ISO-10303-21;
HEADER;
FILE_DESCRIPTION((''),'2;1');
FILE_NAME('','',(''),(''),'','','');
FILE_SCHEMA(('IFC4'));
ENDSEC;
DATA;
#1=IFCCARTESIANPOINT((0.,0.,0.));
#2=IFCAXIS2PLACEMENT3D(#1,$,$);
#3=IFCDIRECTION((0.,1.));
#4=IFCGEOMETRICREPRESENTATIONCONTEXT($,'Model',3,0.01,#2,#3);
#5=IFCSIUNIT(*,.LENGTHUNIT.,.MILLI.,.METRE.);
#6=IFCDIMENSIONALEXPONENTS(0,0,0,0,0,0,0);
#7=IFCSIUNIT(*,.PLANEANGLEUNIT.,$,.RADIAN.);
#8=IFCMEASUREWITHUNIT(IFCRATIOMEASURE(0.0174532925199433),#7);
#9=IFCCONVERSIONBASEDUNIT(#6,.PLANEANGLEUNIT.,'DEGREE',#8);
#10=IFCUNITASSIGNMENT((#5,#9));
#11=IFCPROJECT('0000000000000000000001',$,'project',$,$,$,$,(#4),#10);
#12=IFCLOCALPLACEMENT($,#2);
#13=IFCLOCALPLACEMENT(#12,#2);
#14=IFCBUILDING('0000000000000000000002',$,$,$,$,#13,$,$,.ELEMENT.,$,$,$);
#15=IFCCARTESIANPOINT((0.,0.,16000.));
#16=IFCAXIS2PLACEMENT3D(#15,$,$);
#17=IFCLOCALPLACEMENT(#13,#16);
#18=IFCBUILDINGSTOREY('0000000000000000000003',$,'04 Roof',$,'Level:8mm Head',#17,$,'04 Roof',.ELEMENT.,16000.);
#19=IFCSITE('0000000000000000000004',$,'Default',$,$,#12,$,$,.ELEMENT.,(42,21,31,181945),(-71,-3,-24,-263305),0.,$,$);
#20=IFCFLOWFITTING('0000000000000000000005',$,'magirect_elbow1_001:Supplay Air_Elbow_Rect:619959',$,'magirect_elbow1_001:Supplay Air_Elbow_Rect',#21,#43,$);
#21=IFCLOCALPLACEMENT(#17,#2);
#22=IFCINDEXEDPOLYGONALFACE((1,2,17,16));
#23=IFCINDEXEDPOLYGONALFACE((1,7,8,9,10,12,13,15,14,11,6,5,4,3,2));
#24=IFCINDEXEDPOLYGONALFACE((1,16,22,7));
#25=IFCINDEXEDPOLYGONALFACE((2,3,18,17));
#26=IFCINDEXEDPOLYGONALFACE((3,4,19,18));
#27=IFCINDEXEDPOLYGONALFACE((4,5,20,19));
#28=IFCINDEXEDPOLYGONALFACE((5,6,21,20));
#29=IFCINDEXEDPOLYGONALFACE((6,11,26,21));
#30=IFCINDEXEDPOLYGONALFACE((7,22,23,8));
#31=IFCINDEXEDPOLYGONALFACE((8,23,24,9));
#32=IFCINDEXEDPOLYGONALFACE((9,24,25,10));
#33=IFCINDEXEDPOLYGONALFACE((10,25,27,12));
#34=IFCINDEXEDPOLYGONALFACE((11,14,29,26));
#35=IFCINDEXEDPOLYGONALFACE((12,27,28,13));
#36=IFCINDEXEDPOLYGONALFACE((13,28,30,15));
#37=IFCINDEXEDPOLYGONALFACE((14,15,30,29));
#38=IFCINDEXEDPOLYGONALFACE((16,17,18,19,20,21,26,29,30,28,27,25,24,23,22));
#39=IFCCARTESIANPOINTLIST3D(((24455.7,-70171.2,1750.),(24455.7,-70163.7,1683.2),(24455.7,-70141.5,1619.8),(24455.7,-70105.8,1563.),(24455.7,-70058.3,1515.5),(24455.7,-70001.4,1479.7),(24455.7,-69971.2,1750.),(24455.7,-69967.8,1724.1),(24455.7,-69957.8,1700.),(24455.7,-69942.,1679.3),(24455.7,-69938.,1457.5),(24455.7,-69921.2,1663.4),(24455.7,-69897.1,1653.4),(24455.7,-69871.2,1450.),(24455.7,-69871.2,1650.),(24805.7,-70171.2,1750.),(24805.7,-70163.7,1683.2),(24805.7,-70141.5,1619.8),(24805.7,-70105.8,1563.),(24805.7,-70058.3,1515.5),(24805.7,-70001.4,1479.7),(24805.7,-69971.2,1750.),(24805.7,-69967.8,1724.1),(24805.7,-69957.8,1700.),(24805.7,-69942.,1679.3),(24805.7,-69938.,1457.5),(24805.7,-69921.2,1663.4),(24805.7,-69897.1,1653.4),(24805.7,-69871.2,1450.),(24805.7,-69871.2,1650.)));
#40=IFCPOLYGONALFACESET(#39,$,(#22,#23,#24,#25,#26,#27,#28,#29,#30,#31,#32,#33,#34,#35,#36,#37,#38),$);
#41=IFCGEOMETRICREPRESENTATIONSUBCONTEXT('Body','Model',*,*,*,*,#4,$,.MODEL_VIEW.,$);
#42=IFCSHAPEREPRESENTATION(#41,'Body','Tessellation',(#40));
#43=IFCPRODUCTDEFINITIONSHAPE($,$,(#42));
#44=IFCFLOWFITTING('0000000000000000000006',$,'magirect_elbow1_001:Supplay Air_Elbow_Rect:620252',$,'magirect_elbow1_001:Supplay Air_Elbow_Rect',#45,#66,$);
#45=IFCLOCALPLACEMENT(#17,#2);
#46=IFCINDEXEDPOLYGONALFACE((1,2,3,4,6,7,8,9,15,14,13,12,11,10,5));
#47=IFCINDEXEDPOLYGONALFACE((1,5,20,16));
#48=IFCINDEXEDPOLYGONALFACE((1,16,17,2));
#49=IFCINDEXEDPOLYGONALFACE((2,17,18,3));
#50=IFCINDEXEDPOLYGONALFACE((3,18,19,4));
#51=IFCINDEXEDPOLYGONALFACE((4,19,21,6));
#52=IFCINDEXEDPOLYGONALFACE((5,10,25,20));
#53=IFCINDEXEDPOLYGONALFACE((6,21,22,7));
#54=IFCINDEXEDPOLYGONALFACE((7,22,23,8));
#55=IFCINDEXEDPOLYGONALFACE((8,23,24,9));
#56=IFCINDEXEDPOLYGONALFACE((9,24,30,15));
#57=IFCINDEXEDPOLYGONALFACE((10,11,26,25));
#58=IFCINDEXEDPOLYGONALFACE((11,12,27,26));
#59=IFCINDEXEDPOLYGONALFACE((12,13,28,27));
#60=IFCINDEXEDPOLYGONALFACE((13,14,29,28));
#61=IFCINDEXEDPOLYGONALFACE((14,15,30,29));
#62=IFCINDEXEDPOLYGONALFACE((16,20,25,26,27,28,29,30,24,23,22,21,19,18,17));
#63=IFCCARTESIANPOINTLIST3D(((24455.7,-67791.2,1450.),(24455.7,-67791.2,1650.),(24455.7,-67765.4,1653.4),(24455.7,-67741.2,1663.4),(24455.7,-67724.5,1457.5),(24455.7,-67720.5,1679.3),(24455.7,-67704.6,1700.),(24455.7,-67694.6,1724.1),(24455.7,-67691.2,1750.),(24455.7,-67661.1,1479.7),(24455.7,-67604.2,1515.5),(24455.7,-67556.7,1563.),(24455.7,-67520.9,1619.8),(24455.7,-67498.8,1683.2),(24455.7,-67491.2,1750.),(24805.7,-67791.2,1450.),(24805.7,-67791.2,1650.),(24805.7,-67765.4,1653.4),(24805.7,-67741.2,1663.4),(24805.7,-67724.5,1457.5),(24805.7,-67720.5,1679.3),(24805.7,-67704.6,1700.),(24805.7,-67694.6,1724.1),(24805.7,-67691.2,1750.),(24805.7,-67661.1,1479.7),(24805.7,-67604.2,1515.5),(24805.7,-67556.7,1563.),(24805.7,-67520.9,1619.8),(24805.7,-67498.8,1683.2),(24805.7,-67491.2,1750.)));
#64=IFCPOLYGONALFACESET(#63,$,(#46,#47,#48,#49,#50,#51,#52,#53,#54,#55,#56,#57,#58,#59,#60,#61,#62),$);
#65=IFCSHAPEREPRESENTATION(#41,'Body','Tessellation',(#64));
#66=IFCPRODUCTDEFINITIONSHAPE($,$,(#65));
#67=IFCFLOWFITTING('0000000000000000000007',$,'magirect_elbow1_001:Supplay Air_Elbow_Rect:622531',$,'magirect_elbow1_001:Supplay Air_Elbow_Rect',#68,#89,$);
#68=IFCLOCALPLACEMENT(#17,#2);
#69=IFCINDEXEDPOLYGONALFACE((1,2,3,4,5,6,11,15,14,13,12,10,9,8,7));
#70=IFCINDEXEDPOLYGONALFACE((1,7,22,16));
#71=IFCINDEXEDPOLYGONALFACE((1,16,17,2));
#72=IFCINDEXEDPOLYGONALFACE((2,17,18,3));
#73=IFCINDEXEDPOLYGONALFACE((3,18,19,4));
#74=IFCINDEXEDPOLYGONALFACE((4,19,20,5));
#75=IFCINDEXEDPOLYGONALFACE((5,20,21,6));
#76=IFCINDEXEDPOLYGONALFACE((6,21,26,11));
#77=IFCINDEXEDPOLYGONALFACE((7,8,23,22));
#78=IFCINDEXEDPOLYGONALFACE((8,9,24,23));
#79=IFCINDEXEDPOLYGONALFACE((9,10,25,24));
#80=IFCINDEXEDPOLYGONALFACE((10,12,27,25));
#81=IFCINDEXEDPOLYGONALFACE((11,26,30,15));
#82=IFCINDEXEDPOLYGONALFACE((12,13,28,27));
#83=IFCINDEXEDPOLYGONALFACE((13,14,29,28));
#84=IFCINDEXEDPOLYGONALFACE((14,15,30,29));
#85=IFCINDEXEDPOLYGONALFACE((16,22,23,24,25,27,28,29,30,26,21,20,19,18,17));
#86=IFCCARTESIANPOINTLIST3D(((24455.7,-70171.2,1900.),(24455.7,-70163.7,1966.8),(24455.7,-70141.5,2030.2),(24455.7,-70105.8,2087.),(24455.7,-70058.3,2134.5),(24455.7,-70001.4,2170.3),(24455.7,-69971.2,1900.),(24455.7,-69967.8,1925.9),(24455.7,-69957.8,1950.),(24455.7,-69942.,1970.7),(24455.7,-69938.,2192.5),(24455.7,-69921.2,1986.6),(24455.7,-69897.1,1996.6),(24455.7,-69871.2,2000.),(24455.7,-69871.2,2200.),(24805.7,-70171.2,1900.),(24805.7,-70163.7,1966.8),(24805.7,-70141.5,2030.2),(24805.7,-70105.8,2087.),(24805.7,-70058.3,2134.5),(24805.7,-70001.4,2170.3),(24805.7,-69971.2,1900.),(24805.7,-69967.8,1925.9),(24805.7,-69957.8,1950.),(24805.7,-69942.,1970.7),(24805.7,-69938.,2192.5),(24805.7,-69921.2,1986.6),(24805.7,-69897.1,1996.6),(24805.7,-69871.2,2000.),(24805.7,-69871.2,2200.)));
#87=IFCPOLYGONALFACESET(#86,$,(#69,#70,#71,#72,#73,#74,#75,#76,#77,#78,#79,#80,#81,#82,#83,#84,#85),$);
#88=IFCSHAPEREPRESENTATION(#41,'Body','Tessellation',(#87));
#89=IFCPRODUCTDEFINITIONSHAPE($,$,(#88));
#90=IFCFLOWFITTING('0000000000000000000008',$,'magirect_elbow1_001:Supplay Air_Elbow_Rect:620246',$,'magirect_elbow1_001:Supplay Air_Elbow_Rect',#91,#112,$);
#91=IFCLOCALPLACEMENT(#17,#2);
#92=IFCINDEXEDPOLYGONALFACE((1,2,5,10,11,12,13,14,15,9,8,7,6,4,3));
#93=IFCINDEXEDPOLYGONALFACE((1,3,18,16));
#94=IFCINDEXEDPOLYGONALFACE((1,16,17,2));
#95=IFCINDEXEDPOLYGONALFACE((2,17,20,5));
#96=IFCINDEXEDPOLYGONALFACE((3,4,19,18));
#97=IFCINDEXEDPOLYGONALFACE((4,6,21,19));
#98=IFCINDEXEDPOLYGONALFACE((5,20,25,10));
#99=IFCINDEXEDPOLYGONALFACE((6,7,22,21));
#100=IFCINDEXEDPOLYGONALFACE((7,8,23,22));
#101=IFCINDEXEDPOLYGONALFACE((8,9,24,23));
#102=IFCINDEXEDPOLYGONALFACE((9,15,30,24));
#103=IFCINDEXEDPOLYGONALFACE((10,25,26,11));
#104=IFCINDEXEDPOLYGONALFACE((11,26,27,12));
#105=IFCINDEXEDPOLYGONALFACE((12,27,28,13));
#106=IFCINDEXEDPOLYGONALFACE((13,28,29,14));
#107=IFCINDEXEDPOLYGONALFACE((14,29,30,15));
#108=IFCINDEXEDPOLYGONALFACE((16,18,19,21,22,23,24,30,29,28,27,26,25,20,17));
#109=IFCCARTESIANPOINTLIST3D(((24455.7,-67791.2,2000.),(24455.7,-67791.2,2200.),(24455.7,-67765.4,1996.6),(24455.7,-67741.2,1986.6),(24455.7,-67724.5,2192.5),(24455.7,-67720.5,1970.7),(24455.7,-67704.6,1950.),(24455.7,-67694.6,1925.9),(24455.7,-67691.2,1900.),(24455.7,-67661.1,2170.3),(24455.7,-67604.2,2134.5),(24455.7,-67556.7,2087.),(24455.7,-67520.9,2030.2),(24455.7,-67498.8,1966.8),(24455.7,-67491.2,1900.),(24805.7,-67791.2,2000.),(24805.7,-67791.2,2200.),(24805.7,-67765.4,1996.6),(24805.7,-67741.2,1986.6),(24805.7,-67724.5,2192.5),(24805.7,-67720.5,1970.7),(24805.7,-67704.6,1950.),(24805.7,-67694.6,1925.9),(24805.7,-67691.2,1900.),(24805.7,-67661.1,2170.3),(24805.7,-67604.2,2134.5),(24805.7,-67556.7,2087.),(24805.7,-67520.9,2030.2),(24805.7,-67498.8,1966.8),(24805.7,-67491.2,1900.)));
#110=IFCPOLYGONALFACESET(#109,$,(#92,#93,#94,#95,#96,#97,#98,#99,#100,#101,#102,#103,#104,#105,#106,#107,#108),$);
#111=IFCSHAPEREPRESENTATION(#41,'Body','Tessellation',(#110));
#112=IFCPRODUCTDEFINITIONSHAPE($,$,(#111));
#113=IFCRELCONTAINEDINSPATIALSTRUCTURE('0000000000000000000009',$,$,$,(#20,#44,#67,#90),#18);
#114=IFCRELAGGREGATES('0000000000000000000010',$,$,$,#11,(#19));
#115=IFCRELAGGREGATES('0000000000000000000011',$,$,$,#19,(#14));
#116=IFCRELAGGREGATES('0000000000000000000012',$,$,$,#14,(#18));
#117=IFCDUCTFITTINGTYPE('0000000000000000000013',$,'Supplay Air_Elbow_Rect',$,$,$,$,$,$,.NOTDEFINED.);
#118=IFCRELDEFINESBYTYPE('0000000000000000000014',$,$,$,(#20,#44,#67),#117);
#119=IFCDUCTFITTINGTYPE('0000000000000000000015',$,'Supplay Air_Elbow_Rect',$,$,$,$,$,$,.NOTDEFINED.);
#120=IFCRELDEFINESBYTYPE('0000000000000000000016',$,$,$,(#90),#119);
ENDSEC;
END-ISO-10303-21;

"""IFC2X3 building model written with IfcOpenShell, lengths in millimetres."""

from ifc_helpers import new_model, entity, si_unit, converted_unit, direction, frame, frame_2d, origin, place, context, subcontext, project, spatial, polyline, circle_curve, parameter, trimmed, segment, composite_curve, outline, extrude, source, transform, mapped, type_object, type_shapes, element, save


model = new_model("IFC2X3")

# Units and contexts
model_context = context("Model", 3, precision=0.01, world=origin(), true_north=direction((0.0, 1.0)))
body_context = subcontext(model_context, "Body", "Model", "MODEL_VIEW")
ifc_project = project(units=[si_unit("LENGTHUNIT", "METRE", prefix="MILLI"), converted_unit("PLANEANGLEUNIT", "DEGREE", entity("IfcRatioMeasure", 0.0174532925199433), si_unit("PLANEANGLEUNIT", "RADIAN"), dimensions=[0, 0, 0, 0, 0, 0, 0])], contexts=[model_context])

# Site, building, storey
site_placement = place(None, origin())
site = spatial("IfcSite", under=ifc_project, at=site_placement, Name="Default", CompositionType="ELEMENT", RefLatitude=(42, 21, 31, 181945), RefLongitude=(-71, -3, -24, -263305), RefElevation=0.0)
building_placement = place(site_placement, origin())
building = spatial("IfcBuilding", under=site, at=building_placement, CompositionType="ELEMENT")
storey_placement = place(building_placement, frame((0.0, 0.0, 16000.0)))
storey = spatial("IfcBuildingStorey", under=building, at=storey_placement, Name="04 Roof", ObjectType="Level:8mm Head", LongName="04 Roof", CompositionType="ELEMENT", Elevation=16000.0)

# Flow fittings
duct_fitting_type_1 = type_object("IfcDuctFittingType", Name="Supplay Air_Elbow_Rect", PredefinedType="NOTDEFINED")
shared_shape_1 = source(origin(), body_context, "Body", "SweptSolid", [
    extrude(outline(composite_curve([segment(polyline([(-200.0, -100.0), (0.0, -100.0)]), True, "CONTINUOUS"), segment(trimmed(circle_curve(frame_2d((100.0, -100.0), x_axis=(0.0, 1.0)), 100.0), [parameter(0.0)], [parameter(90.0)], True, "PARAMETER"), False, "CONTINUOUS"), segment(polyline([(100.0, 0.0), (100.0, 200.0)]), True, "CONTINUOUS"), segment(trimmed(circle_curve(frame_2d((100.0, -100.0), x_axis=(0.0, 1.0)), 300.0), [parameter(0.0)], [parameter(90.0)], True, "PARAMETER"), True, "CONTINUOUS")], self_intersect=False)), frame((-100.0, 100.0, -175.0), z_axis=(0.0, 0.0, 1.0), x_axis=(-1.0, 0.0, 0.0)), (0.0, 0.0, 1.0), 350.0),
])
type_shapes(duct_fitting_type_1, [shared_shape_1])
for number, where, z_axis, x_axis, name in (
    (1, (24630.7, -70071.2, 1550.0), (-1.0, 0.0, 0.0), (0.0, -1.0, 0.0), "magirect_elbow1_001:Supplay Air_Elbow_Rect:619959"),
    (2, (24630.7, -67591.2, 1550.0), (-1.0, 0.0, 0.0), (0.0, 0.0, -1.0), "magirect_elbow1_001:Supplay Air_Elbow_Rect:620252"),
    (3, (24630.7, -70071.2, 2100.0), (-1.0, 0.0, 0.0), (0.0, 0.0, 1.0), "magirect_elbow1_001:Supplay Air_Elbow_Rect:622531"),
):
    element("IfcFlowFitting", number, at=place(storey_placement, frame(where, z_axis=z_axis, x_axis=x_axis)), inside=storey, type_object=duct_fitting_type_1, Name=name, ObjectType="magirect_elbow1_001:Supplay Air_Elbow_Rect", context=body_context, shape_type="MappedRepresentation", body=[
        mapped(shared_shape_1, transform((0.0, 0.0, 0.0), scale=1.0)),
    ])
duct_fitting_type_2 = type_object("IfcDuctFittingType", Name="Supplay Air_Elbow_Rect", PredefinedType="NOTDEFINED")
shared_shape_2 = source(origin(), body_context, "Body", "SweptSolid", [
    extrude(outline(composite_curve([segment(trimmed(circle_curve(frame_2d((-100.0, 100.0), x_axis=(1.0, 0.0)), 300.0), [parameter(270.0)], [parameter(0.0)], True, "PARAMETER"), True, "CONTINUOUS"), segment(polyline([(200.0, 100.0), (0.0, 100.0)]), True, "CONTINUOUS"), segment(trimmed(circle_curve(frame_2d((-100.0, 100.0), x_axis=(1.0, 0.0)), 100.0), [parameter(270.0)], [parameter(0.0)], True, "PARAMETER"), False, "CONTINUOUS"), segment(polyline([(-100.0, 0.0), (-100.0, -200.0)]), True, "CONTINUOUS")], self_intersect=False)), frame((-100.0, -100.0, -175.0), z_axis=(0.0, 0.0, 1.0), x_axis=(0.0, 1.0, 0.0)), (0.0, 0.0, 1.0), 350.0),
])
type_shapes(duct_fitting_type_2, [shared_shape_2])
flow_fitting_1_placement = place(storey_placement, frame((24630.7, -67591.2, 2100.0), z_axis=(-1.0, 0.0, 0.0), x_axis=(0.0, 0.0, 1.0)))
element("IfcFlowFitting", 4, at=flow_fitting_1_placement, inside=storey, type_object=duct_fitting_type_2, Name="magirect_elbow1_001:Supplay Air_Elbow_Rect:620246", ObjectType="magirect_elbow1_001:Supplay Air_Elbow_Rect", context=body_context, shape_type="MappedRepresentation", body=[
    mapped(shared_shape_2, transform((0.0, 0.0, 0.0), scale=1.0)),
])

save(model, "model.ifc")
